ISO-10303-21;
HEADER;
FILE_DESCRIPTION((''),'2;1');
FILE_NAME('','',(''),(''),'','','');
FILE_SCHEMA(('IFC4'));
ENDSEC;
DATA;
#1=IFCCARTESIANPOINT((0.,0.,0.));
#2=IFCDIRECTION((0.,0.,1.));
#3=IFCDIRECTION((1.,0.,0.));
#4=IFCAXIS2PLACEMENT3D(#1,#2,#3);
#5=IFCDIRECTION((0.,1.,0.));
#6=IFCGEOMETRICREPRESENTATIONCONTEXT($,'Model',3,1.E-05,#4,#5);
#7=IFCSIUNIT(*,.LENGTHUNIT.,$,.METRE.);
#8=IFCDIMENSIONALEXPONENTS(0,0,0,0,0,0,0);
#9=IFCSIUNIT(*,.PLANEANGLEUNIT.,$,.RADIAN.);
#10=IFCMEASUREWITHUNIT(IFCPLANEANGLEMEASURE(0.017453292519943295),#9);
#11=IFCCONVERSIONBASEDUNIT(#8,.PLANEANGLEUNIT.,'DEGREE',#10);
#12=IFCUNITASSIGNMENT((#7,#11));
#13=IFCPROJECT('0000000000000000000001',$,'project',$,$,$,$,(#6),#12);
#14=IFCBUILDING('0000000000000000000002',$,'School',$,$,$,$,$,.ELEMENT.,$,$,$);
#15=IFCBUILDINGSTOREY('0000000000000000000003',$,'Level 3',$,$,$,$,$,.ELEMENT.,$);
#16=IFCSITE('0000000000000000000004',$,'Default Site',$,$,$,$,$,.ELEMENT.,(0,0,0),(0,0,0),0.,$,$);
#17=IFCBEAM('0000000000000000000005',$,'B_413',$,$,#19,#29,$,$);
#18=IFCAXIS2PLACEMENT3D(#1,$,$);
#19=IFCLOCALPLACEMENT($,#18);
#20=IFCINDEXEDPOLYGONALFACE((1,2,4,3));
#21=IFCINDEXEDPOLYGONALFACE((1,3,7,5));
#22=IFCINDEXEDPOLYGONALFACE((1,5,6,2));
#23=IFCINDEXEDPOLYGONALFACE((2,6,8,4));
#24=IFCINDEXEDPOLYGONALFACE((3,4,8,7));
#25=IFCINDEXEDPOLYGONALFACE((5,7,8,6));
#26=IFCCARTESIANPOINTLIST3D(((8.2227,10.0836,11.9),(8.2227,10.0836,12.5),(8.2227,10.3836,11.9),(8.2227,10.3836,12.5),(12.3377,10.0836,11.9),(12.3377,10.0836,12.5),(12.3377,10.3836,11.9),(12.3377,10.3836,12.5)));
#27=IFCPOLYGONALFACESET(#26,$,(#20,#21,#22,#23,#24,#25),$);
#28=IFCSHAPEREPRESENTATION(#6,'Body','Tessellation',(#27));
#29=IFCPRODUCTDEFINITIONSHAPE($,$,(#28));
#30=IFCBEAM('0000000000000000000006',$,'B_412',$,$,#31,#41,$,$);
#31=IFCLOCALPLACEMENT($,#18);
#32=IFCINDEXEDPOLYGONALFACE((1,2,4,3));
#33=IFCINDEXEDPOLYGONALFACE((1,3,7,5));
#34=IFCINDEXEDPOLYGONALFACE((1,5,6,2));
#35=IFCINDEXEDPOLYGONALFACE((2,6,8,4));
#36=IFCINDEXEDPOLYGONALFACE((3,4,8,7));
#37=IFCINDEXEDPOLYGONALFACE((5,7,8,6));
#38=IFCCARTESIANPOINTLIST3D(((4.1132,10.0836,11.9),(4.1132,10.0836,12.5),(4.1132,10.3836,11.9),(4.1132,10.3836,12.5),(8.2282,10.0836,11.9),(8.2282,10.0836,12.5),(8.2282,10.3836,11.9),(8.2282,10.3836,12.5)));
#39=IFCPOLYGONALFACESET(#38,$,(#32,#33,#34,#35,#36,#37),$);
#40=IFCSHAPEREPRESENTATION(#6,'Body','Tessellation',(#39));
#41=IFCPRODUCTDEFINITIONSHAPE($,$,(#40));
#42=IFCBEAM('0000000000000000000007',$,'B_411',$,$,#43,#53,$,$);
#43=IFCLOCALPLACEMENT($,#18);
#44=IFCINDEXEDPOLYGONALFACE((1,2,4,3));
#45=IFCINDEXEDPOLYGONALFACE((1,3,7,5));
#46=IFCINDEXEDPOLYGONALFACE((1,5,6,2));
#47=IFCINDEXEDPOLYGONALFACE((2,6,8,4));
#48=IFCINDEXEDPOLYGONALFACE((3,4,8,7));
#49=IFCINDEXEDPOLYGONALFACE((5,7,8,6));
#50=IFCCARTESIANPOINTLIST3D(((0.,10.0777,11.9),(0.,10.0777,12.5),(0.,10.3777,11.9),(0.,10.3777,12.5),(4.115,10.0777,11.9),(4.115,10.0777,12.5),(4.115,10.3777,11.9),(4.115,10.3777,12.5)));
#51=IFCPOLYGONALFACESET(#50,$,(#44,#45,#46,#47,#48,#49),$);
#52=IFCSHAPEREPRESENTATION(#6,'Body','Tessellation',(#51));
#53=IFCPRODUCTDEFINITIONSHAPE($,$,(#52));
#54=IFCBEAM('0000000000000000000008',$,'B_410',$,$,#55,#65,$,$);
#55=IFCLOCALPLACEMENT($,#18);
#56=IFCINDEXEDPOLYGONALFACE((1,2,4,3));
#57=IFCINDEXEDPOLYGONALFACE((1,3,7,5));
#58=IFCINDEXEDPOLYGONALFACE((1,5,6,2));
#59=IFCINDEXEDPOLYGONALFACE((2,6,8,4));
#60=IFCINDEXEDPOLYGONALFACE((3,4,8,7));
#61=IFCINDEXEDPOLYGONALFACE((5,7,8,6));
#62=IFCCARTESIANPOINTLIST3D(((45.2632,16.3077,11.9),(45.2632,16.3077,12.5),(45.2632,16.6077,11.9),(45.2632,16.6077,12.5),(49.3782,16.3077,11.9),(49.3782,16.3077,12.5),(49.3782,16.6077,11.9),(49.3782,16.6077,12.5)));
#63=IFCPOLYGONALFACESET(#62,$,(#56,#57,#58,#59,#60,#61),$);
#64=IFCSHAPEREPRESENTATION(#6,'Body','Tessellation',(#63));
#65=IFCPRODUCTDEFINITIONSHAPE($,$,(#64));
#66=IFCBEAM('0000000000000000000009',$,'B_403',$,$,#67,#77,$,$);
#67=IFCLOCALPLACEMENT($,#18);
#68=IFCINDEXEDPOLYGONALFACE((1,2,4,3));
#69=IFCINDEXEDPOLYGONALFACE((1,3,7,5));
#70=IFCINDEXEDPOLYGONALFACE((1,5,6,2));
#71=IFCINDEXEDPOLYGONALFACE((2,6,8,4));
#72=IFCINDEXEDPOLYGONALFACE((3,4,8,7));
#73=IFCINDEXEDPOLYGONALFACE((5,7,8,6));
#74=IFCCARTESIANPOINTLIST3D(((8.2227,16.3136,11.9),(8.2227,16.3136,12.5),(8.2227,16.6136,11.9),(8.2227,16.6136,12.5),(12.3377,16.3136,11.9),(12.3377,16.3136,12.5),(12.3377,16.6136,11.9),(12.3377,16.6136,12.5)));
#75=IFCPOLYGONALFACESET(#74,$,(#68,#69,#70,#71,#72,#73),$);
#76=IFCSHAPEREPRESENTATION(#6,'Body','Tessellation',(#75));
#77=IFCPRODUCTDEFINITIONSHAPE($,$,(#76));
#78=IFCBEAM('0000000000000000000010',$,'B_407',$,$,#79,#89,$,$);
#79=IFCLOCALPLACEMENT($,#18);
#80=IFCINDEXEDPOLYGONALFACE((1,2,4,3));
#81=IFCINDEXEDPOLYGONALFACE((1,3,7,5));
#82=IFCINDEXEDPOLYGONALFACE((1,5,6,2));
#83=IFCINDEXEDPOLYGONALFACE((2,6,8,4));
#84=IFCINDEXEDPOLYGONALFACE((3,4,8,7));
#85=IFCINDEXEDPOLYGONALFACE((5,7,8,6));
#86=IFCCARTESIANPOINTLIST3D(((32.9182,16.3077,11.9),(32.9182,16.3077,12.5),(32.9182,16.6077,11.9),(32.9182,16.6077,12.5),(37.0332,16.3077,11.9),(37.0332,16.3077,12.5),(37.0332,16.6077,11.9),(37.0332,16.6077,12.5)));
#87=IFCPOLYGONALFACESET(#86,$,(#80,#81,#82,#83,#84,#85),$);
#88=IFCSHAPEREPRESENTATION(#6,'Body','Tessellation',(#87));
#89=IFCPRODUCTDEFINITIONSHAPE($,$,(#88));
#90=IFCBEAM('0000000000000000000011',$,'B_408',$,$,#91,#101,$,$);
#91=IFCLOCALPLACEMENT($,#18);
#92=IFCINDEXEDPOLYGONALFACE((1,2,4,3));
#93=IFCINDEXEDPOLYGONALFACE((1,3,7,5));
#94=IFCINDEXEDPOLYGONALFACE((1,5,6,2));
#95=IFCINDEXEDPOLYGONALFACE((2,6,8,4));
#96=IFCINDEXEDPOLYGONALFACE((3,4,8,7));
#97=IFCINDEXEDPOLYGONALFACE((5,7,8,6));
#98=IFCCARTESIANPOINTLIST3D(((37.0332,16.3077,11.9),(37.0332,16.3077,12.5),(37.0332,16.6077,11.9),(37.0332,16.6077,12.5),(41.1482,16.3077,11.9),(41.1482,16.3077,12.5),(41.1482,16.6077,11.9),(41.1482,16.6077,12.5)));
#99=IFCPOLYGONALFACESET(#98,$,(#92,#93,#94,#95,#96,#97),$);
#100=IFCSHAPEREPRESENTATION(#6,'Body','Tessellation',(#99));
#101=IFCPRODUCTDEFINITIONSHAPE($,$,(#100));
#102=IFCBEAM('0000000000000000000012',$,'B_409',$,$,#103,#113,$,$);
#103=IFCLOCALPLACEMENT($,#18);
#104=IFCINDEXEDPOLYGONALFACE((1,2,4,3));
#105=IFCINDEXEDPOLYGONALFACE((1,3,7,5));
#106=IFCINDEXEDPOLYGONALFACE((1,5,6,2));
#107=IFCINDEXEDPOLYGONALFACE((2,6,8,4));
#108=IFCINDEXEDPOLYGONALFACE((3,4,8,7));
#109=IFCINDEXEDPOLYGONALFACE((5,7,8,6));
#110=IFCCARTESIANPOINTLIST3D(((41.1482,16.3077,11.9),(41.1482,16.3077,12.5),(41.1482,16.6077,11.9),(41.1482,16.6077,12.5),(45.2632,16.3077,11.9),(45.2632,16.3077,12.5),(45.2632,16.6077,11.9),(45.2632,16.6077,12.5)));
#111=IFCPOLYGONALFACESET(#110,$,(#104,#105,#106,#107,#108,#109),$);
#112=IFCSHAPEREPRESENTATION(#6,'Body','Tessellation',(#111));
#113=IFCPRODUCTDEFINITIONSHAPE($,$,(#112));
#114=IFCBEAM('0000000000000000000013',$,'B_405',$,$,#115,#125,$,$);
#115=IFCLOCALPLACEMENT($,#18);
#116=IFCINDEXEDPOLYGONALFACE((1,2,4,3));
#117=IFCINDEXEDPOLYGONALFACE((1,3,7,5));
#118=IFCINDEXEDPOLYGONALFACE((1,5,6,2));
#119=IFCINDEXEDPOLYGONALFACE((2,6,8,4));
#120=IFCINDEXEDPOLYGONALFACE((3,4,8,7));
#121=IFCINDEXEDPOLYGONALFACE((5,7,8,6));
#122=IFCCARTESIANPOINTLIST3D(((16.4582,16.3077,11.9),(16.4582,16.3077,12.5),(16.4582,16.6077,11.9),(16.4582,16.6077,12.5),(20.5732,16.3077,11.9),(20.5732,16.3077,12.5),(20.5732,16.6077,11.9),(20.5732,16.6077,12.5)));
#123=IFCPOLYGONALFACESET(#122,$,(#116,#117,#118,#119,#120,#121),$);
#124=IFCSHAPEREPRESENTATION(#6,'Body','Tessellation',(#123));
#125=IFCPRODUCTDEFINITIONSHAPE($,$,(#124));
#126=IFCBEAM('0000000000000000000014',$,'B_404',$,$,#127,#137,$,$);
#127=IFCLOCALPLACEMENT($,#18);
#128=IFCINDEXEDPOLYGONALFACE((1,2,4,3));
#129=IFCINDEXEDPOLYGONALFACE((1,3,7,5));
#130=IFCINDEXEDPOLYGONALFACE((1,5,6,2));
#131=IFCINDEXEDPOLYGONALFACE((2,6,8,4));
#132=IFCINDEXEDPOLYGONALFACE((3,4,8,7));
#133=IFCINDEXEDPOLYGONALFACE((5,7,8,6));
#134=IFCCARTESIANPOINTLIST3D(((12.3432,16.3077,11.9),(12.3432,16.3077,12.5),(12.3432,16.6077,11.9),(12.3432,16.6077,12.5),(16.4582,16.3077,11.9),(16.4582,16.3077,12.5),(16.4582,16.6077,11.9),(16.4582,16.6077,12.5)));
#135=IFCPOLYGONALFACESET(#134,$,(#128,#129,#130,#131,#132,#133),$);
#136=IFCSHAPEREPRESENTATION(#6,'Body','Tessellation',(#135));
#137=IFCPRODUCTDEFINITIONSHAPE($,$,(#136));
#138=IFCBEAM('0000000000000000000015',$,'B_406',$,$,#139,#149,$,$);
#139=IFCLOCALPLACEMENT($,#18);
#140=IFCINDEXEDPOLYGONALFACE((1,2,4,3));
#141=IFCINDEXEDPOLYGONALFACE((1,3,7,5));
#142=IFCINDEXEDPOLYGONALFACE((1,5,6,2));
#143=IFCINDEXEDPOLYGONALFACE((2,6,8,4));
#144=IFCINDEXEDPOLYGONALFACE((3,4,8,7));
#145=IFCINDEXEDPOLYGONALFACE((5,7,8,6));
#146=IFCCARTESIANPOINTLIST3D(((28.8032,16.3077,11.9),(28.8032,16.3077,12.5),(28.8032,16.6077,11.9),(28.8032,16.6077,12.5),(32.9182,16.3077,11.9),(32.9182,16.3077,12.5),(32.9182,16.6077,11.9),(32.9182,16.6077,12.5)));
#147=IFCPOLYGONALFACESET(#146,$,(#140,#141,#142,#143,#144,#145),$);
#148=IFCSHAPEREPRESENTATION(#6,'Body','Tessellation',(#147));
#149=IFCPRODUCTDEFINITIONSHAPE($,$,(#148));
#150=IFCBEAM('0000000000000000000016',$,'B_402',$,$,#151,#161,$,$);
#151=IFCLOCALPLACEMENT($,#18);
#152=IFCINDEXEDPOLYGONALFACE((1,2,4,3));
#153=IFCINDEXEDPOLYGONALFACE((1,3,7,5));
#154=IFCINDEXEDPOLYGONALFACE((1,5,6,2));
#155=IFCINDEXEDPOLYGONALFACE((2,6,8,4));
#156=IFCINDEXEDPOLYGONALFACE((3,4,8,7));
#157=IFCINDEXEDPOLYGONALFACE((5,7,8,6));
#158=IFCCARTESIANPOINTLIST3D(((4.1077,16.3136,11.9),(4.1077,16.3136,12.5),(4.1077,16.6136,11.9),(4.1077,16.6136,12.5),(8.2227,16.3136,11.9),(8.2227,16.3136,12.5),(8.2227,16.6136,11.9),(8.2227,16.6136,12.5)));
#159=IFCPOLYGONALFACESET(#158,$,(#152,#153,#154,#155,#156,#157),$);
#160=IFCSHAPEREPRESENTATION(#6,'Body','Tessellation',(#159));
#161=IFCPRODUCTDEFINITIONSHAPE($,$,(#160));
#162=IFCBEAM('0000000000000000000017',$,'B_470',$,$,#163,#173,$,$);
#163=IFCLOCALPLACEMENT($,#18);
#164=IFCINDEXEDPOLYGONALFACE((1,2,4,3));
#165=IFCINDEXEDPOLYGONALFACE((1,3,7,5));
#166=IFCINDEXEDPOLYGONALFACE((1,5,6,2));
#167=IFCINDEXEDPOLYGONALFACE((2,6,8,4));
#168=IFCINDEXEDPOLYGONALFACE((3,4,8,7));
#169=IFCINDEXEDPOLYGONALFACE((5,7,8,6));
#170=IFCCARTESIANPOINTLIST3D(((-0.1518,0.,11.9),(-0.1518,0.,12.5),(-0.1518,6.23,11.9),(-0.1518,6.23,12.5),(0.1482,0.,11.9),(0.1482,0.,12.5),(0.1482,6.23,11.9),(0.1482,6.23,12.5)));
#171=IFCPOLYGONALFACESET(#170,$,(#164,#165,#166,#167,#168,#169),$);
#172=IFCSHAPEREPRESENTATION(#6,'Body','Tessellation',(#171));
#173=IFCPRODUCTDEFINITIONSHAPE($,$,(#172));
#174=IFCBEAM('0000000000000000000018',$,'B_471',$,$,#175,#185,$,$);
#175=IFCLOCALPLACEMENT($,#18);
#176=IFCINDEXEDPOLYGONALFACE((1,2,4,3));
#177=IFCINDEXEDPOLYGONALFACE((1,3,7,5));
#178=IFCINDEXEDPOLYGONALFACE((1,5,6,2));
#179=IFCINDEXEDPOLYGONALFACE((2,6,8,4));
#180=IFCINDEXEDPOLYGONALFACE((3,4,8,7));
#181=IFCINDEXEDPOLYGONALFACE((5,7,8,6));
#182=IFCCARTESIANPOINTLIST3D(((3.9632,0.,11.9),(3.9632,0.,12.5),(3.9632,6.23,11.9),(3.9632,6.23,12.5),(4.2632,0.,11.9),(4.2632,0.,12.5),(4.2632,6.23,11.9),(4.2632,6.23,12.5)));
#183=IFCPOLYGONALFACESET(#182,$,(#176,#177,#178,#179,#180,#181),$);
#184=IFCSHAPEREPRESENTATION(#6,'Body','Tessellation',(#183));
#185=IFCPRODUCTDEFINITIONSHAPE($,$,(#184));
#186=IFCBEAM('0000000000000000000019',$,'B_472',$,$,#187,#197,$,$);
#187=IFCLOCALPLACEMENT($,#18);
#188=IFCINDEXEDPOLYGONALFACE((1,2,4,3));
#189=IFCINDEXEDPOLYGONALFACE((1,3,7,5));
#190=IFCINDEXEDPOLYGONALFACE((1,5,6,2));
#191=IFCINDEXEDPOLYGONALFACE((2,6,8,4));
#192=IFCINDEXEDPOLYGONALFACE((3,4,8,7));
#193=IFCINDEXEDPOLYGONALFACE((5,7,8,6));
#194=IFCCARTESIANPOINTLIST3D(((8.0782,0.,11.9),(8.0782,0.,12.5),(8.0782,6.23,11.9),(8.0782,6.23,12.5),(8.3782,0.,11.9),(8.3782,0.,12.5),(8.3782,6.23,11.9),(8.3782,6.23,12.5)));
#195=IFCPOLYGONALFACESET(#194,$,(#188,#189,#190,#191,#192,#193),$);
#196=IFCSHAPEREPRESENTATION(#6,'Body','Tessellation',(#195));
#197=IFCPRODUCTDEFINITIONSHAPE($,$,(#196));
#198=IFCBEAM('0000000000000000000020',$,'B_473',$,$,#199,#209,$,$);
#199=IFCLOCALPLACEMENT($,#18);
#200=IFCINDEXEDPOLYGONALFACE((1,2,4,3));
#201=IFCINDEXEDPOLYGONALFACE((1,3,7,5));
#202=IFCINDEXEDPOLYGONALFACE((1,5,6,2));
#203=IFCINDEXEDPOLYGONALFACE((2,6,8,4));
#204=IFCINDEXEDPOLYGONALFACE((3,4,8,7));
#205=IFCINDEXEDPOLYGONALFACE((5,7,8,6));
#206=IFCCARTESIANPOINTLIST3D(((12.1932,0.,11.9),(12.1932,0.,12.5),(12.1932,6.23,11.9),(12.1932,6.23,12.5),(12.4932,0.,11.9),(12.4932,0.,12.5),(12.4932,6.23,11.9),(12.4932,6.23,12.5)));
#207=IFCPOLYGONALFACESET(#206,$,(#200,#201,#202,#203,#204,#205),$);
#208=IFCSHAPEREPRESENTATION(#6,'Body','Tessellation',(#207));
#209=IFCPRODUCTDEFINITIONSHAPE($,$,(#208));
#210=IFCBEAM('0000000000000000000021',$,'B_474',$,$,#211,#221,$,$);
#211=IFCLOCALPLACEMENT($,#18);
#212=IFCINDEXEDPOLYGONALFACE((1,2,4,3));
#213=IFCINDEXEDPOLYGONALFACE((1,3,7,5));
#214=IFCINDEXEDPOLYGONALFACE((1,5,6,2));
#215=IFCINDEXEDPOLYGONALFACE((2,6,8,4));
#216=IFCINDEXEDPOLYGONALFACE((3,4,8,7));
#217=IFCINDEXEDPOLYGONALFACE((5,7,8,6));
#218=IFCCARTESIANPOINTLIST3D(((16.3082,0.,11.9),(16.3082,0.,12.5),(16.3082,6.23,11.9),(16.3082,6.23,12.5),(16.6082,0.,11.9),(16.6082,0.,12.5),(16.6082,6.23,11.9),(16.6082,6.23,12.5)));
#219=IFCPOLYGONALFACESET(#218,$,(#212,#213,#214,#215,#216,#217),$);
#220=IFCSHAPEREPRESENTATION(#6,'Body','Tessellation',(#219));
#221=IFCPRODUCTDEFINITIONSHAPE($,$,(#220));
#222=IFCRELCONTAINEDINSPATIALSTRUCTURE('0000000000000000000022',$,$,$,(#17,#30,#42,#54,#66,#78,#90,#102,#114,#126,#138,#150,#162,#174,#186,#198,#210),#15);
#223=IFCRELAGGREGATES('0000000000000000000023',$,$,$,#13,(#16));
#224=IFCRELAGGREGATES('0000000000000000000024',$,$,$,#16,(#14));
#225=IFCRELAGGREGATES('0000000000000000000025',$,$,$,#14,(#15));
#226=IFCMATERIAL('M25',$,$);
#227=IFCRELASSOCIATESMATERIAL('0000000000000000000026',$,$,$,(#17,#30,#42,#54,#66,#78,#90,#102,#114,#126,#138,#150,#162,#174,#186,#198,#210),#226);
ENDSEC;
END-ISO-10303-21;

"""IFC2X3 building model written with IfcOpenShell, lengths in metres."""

from ifc_helpers import new_model, entity, si_unit, converted_unit, direction, frame, frame_2d, origin_with_axes, place, context, project, spatial, rectangle, extrude, material, element, save


model = new_model("IFC2X3")

# Units and contexts
model_context = context("Model", 3, precision=1e-05, world=origin_with_axes(), true_north=direction((0.0, 1.0, 0.0)))
ifc_project = project(units=[si_unit("LENGTHUNIT", "METRE"), converted_unit("PLANEANGLEUNIT", "DEGREE", entity("IfcPlaneAngleMeasure", 0.017453292519943295), si_unit("PLANEANGLEUNIT", "RADIAN"), dimensions=[0, 0, 0, 0, 0, 0, 0])], contexts=[model_context])

# Site, building, storey
site = spatial("IfcSite", under=ifc_project, Name="Default Site", CompositionType="ELEMENT", RefLatitude=(0, 0, 0), RefLongitude=(0, 0, 0), RefElevation=0.0)
building = spatial("IfcBuilding", under=site, Name="School", CompositionType="ELEMENT")
storey = spatial("IfcBuildingStorey", under=building, Name="Level 3", CompositionType="ELEMENT")

# Beams
ifc_material = material(Name="M25")
placement = place(None, origin_with_axes())
element("IfcBeam", 1, at=placement, inside=storey, material=ifc_material, Name="B_413", context=model_context, shape_type="SweptSolid", body=[
    extrude(rectangle(XDim=0.3, YDim=0.6, at=frame_2d((0.0, 0.0), x_axis=(0.0, 1.0, 0.0))), frame((8.2227, 10.2336, 12.2), z_axis=(1.0, 0.0, 0.0), x_axis=(0.0, 0.0, -1.0)), (0.0, 0.0, 1.0), 4.115),
])
element("IfcBeam", 2, at=placement, inside=storey, material=ifc_material, Name="B_412", context=model_context, shape_type="SweptSolid", body=[
    extrude(rectangle(XDim=0.3, YDim=0.6, at=frame_2d((0.0, 0.0), x_axis=(0.0, 1.0, 0.0))), frame((4.1132, 10.2336, 12.2), z_axis=(1.0, 0.0, 0.0), x_axis=(0.0, 0.0, -1.0)), (0.0, 0.0, 1.0), 4.115),
])
element("IfcBeam", 3, at=placement, inside=storey, material=ifc_material, Name="B_411", context=model_context, shape_type="SweptSolid", body=[
    extrude(rectangle(XDim=0.3, YDim=0.6, at=frame_2d((0.0, 0.0), x_axis=(0.0, 1.0, 0.0))), frame((0.0, 10.2277, 12.2), z_axis=(1.0, 0.0, 0.0), x_axis=(0.0, 0.0, -1.0)), (0.0, 0.0, 1.0), 4.115),
])
element("IfcBeam", 4, at=placement, inside=storey, material=ifc_material, Name="B_410", context=model_context, shape_type="SweptSolid", body=[
    extrude(rectangle(XDim=0.3, YDim=0.6, at=frame_2d((0.0, 0.0), x_axis=(0.0, 1.0, 0.0))), frame((45.2632, 16.4577, 12.2), z_axis=(1.0, 0.0, 0.0), x_axis=(0.0, 0.0, -1.0)), (0.0, 0.0, 1.0), 4.115),
])
element("IfcBeam", 5, at=placement, inside=storey, material=ifc_material, Name="B_403", context=model_context, shape_type="SweptSolid", body=[
    extrude(rectangle(XDim=0.3, YDim=0.6, at=frame_2d((0.0, 0.0), x_axis=(0.0, 1.0, 0.0))), frame((8.2227, 16.4636, 12.2), z_axis=(1.0, 0.0, 0.0), x_axis=(0.0, 0.0, -1.0)), (0.0, 0.0, 1.0), 4.115),
])
element("IfcBeam", 6, at=placement, inside=storey, material=ifc_material, Name="B_407", context=model_context, shape_type="SweptSolid", body=[
    extrude(rectangle(XDim=0.3, YDim=0.6, at=frame_2d((0.0, 0.0), x_axis=(0.0, 1.0, 0.0))), frame((32.9182, 16.4577, 12.2), z_axis=(1.0, 0.0, 0.0), x_axis=(0.0, 0.0, -1.0)), (0.0, 0.0, 1.0), 4.115),
])
element("IfcBeam", 7, at=placement, inside=storey, material=ifc_material, Name="B_408", context=model_context, shape_type="SweptSolid", body=[
    extrude(rectangle(XDim=0.3, YDim=0.6, at=frame_2d((0.0, 0.0), x_axis=(0.0, 1.0, 0.0))), frame((37.0332, 16.4577, 12.2), z_axis=(1.0, 0.0, 0.0), x_axis=(0.0, 0.0, -1.0)), (0.0, 0.0, 1.0), 4.115),
])
element("IfcBeam", 8, at=placement, inside=storey, material=ifc_material, Name="B_409", context=model_context, shape_type="SweptSolid", body=[
    extrude(rectangle(XDim=0.3, YDim=0.6, at=frame_2d((0.0, 0.0), x_axis=(0.0, 1.0, 0.0))), frame((41.1482, 16.4577, 12.2), z_axis=(1.0, 0.0, 0.0), x_axis=(0.0, 0.0, -1.0)), (0.0, 0.0, 1.0), 4.115),
])
element("IfcBeam", 9, at=placement, inside=storey, material=ifc_material, Name="B_405", context=model_context, shape_type="SweptSolid", body=[
    extrude(rectangle(XDim=0.3, YDim=0.6, at=frame_2d((0.0, 0.0), x_axis=(0.0, 1.0, 0.0))), frame((16.4582, 16.4577, 12.2), z_axis=(1.0, 0.0, 0.0), x_axis=(0.0, 0.0, -1.0)), (0.0, 0.0, 1.0), 4.115),
])
element("IfcBeam", 10, at=placement, inside=storey, material=ifc_material, Name="B_404", context=model_context, shape_type="SweptSolid", body=[
    extrude(rectangle(XDim=0.3, YDim=0.6, at=frame_2d((0.0, 0.0), x_axis=(0.0, 1.0, 0.0))), frame((12.3432, 16.4577, 12.2), z_axis=(1.0, 0.0, 0.0), x_axis=(0.0, 0.0, -1.0)), (0.0, 0.0, 1.0), 4.115),
])
element("IfcBeam", 11, at=placement, inside=storey, material=ifc_material, Name="B_406", context=model_context, shape_type="SweptSolid", body=[
    extrude(rectangle(XDim=0.3, YDim=0.6, at=frame_2d((0.0, 0.0), x_axis=(0.0, 1.0, 0.0))), frame((28.8032, 16.4577, 12.2), z_axis=(1.0, 0.0, 0.0), x_axis=(0.0, 0.0, -1.0)), (0.0, 0.0, 1.0), 4.115),
])
element("IfcBeam", 12, at=placement, inside=storey, material=ifc_material, Name="B_402", context=model_context, shape_type="SweptSolid", body=[
    extrude(rectangle(XDim=0.3, YDim=0.6, at=frame_2d((0.0, 0.0), x_axis=(0.0, 1.0, 0.0))), frame((4.1077, 16.4636, 12.2), z_axis=(1.0, 0.0, 0.0), x_axis=(0.0, 0.0, -1.0)), (0.0, 0.0, 1.0), 4.115),
])
element("IfcBeam", 13, at=placement, inside=storey, material=ifc_material, Name="B_470", context=model_context, shape_type="SweptSolid", body=[
    extrude(rectangle(XDim=0.3, YDim=0.6, at=frame_2d((0.0, 0.0), x_axis=(0.0, 1.0, 0.0))), frame((-0.0018, 0.0, 12.2), z_axis=(0.0, 1.0, 0.0), x_axis=(0.0, 0.0, -1.0)), (0.0, 0.0, 1.0), 6.23),
])
element("IfcBeam", 14, at=placement, inside=storey, material=ifc_material, Name="B_471", context=model_context, shape_type="SweptSolid", body=[
    extrude(rectangle(XDim=0.3, YDim=0.6, at=frame_2d((0.0, 0.0), x_axis=(0.0, 1.0, 0.0))), frame((4.1132, 0.0, 12.2), z_axis=(0.0, 1.0, 0.0), x_axis=(0.0, 0.0, -1.0)), (0.0, 0.0, 1.0), 6.23),
])
element("IfcBeam", 15, at=placement, inside=storey, material=ifc_material, Name="B_472", context=model_context, shape_type="SweptSolid", body=[
    extrude(rectangle(XDim=0.3, YDim=0.6, at=frame_2d((0.0, 0.0), x_axis=(0.0, 1.0, 0.0))), frame((8.2282, 0.0, 12.2), z_axis=(0.0, 1.0, 0.0), x_axis=(0.0, 0.0, -1.0)), (0.0, 0.0, 1.0), 6.23),
])
element("IfcBeam", 16, at=placement, inside=storey, material=ifc_material, Name="B_473", context=model_context, shape_type="SweptSolid", body=[
    extrude(rectangle(XDim=0.3, YDim=0.6, at=frame_2d((0.0, 0.0), x_axis=(0.0, 1.0, 0.0))), frame((12.3432, 0.0, 12.2), z_axis=(0.0, 1.0, 0.0), x_axis=(0.0, 0.0, -1.0)), (0.0, 0.0, 1.0), 6.23),
])
element("IfcBeam", 17, at=placement, inside=storey, material=ifc_material, Name="B_474", context=model_context, shape_type="SweptSolid", body=[
    extrude(rectangle(XDim=0.3, YDim=0.6, at=frame_2d((0.0, 0.0), x_axis=(0.0, 1.0, 0.0))), frame((16.4582, 0.0, 12.2), z_axis=(0.0, 1.0, 0.0), x_axis=(0.0, 0.0, -1.0)), (0.0, 0.0, 1.0), 6.23),
])

save(model, "model.ifc")
